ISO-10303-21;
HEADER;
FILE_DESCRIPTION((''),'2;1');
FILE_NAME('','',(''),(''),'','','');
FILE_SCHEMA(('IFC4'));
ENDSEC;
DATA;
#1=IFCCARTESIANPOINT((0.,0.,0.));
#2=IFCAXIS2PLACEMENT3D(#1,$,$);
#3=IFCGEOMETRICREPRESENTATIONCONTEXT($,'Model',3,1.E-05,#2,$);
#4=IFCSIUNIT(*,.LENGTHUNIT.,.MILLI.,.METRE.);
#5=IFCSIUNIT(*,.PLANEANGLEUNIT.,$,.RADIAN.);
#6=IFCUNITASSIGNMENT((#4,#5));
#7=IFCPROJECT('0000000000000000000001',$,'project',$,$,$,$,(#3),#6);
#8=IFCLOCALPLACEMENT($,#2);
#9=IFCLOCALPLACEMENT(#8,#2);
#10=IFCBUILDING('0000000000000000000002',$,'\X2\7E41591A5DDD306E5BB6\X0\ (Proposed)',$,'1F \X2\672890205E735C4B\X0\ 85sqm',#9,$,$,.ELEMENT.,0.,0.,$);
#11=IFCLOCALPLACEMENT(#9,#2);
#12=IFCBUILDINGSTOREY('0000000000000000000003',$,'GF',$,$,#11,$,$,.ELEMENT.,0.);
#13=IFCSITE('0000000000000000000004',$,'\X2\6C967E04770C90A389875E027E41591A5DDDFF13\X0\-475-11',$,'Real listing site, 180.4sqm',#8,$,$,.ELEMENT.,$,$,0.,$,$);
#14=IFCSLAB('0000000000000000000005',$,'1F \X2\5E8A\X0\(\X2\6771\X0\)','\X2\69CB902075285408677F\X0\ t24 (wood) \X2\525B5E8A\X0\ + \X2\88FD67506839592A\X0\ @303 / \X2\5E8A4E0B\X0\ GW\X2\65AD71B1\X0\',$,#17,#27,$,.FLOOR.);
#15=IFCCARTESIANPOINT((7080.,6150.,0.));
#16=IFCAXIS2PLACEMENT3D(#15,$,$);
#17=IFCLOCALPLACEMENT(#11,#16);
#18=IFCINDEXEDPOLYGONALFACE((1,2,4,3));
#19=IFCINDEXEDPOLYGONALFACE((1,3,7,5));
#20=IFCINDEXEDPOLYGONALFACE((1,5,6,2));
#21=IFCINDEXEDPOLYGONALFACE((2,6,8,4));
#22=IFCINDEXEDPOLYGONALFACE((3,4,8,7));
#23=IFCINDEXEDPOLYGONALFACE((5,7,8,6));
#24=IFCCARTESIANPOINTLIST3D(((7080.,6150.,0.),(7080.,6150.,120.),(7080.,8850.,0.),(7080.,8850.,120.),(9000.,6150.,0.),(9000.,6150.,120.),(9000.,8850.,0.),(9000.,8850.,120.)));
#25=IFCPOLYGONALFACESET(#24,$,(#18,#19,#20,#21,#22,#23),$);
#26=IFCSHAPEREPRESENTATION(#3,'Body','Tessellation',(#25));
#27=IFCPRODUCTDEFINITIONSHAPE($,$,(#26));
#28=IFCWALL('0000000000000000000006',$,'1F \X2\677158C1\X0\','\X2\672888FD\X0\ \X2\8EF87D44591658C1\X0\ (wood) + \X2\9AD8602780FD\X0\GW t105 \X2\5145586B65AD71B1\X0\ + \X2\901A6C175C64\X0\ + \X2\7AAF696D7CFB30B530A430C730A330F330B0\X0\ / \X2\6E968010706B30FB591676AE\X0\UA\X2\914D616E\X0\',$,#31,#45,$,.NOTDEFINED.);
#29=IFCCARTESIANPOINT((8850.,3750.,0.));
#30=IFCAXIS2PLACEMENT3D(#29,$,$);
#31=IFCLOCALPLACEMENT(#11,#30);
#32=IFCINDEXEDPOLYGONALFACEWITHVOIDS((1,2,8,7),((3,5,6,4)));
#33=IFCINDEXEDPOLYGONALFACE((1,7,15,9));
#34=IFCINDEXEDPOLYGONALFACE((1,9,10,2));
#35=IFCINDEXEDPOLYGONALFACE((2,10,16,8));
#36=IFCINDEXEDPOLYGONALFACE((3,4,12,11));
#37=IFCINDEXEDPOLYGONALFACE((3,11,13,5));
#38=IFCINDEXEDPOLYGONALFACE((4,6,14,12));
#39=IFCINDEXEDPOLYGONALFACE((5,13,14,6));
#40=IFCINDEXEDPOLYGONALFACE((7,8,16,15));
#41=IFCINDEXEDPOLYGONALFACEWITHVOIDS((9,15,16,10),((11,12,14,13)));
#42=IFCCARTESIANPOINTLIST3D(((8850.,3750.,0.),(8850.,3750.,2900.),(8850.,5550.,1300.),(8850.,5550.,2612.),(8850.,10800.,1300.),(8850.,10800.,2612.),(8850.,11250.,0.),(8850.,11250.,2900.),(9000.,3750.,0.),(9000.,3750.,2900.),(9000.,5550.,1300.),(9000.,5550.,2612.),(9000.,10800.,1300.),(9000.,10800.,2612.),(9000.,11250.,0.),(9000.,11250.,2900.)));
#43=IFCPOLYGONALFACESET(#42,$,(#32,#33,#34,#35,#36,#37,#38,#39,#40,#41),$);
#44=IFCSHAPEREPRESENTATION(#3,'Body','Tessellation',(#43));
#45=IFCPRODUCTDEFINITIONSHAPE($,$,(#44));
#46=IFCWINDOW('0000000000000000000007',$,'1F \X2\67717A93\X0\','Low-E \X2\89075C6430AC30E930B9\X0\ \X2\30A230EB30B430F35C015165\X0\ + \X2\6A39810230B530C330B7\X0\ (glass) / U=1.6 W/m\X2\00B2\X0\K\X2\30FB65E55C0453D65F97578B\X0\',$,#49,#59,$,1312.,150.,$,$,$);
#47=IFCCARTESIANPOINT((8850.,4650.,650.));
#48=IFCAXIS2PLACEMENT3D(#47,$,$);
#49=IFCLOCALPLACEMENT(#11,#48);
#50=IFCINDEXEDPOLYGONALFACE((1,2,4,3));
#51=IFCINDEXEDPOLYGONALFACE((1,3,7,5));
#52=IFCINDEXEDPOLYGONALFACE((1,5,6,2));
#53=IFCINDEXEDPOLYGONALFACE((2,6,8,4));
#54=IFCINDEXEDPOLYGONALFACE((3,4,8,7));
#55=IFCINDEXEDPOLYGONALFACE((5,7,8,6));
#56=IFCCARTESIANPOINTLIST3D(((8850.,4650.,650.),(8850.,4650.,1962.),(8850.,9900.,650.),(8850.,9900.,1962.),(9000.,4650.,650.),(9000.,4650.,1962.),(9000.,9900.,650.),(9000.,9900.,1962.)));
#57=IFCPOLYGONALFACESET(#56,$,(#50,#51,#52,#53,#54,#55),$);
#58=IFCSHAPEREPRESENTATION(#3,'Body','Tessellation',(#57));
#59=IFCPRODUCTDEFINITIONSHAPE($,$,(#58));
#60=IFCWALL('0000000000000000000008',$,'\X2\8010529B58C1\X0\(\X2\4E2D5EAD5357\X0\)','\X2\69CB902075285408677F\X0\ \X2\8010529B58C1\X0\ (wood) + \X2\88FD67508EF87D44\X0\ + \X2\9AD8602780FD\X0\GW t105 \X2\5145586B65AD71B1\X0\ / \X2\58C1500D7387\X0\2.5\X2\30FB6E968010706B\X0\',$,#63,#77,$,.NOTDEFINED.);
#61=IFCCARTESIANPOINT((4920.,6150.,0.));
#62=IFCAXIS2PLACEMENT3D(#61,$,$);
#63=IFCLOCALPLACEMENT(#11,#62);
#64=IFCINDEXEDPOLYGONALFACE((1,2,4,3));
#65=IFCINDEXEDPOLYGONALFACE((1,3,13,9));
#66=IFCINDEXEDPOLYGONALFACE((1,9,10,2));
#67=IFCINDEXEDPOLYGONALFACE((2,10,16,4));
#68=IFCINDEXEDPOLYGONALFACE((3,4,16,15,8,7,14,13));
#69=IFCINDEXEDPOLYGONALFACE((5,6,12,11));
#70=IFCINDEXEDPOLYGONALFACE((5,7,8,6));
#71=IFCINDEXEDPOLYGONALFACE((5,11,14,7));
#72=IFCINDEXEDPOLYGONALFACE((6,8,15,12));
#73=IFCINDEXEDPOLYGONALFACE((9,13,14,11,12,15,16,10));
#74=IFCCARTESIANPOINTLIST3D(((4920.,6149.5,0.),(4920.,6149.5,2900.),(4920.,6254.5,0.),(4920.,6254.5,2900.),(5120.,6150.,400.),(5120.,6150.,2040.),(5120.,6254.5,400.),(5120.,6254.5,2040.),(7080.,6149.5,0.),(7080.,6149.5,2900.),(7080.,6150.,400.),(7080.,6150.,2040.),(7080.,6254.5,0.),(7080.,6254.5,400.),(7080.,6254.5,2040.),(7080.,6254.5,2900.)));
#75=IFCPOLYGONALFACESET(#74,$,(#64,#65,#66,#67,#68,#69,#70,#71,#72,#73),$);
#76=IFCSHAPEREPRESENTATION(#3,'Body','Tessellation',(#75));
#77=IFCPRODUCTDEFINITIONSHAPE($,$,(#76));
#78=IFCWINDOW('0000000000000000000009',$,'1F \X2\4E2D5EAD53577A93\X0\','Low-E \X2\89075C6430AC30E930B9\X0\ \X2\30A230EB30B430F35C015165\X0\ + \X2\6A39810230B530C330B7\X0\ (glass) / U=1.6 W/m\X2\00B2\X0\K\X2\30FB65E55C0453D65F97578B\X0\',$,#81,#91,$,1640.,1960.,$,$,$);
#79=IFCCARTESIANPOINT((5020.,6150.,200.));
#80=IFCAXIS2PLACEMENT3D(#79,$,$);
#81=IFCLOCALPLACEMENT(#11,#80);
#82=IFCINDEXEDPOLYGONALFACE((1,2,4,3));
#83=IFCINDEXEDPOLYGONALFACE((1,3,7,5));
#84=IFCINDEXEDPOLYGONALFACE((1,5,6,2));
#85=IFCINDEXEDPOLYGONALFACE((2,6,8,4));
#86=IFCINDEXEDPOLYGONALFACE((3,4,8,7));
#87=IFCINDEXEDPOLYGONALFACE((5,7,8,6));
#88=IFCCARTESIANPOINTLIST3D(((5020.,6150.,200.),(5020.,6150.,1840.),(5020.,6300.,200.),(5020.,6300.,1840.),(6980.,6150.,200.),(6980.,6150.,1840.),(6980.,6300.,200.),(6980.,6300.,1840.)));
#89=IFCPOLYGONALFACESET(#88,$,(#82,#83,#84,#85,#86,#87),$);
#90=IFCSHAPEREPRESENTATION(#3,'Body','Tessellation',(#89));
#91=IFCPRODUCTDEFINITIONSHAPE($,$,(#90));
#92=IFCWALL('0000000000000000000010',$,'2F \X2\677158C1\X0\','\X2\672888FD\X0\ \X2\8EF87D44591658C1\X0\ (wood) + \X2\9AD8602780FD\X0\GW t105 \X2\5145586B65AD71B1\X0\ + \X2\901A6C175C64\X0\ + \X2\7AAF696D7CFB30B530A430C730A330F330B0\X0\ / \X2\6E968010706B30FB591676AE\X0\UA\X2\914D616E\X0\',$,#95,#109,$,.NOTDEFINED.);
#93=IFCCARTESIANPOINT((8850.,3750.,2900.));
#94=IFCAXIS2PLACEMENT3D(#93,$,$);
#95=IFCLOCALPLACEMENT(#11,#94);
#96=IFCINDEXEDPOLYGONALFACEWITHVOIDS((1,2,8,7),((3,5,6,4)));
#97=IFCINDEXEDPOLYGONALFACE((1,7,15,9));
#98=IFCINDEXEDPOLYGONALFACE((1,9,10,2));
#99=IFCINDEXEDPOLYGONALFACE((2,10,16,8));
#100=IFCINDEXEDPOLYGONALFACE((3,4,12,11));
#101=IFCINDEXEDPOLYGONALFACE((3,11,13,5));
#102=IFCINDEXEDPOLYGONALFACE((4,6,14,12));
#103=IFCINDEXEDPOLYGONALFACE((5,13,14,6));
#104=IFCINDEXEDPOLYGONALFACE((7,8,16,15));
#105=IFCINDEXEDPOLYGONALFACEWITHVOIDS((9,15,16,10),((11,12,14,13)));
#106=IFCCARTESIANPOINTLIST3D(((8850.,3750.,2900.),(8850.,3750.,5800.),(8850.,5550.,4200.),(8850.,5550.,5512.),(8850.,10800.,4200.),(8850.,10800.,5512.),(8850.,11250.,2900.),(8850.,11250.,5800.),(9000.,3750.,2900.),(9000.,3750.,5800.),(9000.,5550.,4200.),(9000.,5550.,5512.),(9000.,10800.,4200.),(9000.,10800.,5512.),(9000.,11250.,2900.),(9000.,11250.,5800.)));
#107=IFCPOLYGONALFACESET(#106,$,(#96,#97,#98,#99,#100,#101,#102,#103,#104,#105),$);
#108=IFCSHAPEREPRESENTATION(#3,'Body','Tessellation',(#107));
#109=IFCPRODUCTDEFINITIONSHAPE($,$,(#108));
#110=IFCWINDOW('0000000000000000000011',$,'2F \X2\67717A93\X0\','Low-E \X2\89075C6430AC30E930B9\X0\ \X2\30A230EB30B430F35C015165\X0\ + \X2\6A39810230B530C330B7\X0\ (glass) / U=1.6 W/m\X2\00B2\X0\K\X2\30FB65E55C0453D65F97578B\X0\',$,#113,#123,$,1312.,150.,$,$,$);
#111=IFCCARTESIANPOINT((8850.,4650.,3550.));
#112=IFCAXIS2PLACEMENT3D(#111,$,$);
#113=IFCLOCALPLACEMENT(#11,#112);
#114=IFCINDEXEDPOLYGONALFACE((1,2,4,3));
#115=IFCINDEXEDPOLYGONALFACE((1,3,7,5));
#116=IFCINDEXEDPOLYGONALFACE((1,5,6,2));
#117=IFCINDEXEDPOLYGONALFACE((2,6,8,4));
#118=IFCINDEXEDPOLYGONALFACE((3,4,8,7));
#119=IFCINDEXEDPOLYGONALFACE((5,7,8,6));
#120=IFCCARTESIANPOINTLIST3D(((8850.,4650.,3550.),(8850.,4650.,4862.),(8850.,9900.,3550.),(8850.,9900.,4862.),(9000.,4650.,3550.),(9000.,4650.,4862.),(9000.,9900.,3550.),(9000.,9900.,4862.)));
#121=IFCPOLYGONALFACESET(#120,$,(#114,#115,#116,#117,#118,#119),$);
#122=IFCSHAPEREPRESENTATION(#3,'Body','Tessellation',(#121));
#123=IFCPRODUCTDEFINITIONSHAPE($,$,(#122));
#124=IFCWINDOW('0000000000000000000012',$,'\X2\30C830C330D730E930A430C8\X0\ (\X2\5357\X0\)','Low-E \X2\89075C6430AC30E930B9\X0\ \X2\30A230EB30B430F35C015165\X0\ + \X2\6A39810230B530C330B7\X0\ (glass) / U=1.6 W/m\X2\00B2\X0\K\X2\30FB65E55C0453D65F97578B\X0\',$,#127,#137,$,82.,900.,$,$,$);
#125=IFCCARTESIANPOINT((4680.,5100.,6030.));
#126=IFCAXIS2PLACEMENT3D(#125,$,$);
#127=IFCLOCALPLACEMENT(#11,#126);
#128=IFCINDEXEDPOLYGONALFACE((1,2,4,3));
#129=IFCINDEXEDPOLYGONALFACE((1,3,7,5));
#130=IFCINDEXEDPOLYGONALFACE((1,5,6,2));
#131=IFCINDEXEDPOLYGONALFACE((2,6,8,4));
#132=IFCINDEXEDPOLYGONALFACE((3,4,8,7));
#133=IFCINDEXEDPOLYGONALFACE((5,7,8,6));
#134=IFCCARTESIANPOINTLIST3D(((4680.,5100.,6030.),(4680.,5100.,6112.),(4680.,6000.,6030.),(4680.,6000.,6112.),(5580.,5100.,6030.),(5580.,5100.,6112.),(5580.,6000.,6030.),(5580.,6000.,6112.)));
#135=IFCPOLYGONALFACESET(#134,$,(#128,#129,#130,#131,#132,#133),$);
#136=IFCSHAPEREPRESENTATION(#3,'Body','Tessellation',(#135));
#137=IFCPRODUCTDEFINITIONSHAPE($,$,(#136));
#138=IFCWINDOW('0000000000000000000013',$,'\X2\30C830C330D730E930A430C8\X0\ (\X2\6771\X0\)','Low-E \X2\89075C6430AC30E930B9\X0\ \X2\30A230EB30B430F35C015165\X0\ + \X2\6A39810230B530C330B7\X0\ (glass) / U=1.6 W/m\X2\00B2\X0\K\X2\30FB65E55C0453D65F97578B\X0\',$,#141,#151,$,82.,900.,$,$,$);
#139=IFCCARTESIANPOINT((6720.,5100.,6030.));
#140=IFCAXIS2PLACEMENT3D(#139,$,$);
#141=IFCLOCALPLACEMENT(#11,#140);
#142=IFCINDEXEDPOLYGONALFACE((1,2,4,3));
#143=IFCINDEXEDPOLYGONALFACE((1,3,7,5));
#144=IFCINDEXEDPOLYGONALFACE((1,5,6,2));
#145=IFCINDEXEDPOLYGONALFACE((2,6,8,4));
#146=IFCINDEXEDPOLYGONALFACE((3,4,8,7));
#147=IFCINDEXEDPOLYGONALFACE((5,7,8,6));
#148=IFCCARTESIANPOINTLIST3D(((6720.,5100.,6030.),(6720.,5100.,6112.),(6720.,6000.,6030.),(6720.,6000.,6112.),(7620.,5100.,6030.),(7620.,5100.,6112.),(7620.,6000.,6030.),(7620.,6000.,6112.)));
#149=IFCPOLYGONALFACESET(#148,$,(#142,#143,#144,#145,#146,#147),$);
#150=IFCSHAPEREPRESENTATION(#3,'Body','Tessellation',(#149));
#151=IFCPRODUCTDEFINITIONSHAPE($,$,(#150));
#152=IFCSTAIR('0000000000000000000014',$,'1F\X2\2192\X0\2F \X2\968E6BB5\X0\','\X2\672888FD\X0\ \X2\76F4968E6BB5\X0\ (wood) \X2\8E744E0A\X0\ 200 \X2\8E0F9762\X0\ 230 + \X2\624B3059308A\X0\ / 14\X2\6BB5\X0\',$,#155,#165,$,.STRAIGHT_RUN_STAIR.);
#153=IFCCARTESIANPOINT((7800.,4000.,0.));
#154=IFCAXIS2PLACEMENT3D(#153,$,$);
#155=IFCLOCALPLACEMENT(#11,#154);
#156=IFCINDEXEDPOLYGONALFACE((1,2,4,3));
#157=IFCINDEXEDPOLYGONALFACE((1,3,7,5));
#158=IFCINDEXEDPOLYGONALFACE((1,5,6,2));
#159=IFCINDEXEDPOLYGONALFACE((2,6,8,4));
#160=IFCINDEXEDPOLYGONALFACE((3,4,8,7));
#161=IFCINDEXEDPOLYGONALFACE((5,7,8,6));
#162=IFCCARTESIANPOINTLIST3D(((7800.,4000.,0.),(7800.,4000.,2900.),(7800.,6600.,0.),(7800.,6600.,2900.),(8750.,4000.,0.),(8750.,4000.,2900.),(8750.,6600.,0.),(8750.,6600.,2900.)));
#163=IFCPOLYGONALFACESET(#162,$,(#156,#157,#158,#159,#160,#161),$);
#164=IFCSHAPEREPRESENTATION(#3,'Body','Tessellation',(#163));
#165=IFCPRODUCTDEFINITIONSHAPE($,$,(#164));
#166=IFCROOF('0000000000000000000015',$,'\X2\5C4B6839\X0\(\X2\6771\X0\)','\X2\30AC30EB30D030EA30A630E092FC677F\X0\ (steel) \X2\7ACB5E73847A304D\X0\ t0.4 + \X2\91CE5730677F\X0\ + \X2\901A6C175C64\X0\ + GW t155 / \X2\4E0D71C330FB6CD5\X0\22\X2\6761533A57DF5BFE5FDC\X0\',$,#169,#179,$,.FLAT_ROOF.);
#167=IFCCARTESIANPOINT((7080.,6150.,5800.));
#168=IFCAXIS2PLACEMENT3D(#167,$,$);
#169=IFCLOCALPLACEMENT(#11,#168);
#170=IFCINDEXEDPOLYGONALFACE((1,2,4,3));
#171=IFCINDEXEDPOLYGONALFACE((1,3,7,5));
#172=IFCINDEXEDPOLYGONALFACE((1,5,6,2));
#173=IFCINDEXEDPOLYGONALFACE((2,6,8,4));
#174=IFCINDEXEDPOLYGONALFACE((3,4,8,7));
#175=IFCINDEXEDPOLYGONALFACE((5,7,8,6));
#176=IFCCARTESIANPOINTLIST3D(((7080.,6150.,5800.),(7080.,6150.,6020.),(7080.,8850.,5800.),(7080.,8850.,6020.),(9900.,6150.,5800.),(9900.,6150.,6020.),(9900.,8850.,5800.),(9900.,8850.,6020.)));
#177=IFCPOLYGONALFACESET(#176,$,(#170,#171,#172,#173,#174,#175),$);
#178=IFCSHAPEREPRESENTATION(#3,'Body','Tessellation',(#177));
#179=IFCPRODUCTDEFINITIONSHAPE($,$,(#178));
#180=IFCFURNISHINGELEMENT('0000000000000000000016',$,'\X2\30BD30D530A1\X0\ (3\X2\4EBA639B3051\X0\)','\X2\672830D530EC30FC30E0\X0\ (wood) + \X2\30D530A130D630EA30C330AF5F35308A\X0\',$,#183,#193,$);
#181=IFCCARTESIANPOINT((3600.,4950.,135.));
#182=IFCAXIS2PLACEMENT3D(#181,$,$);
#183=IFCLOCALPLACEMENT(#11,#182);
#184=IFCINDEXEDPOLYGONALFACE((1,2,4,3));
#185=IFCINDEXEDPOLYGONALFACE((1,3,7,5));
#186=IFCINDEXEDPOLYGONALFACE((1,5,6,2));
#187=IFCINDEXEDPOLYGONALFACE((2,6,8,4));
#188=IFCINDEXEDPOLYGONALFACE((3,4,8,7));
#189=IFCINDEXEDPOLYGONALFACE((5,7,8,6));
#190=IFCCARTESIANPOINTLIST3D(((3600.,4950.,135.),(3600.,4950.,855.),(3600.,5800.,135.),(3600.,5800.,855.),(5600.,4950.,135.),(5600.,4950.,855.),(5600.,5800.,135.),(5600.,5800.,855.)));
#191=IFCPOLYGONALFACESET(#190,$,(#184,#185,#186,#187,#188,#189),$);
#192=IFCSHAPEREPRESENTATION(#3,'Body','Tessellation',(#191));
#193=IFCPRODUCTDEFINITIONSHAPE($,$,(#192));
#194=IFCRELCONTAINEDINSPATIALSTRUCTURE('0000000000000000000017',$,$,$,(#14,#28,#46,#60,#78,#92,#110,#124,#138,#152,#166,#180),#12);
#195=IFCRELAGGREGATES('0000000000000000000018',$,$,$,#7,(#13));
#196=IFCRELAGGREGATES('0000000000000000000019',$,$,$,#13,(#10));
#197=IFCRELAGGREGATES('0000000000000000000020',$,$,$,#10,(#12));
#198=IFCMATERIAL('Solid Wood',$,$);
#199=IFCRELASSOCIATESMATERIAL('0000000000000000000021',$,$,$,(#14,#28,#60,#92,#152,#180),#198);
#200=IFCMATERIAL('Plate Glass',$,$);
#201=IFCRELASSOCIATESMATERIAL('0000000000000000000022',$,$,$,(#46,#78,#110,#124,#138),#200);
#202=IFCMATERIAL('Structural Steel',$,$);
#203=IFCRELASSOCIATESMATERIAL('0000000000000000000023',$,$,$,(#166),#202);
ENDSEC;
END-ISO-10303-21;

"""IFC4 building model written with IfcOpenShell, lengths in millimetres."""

from ifc_helpers import new_model, si_unit, frame, frame_2d, origin, place, context, project, spatial, rectangle, extrude, material, element, fill, save


model = new_model("IFC4")

# Units and contexts
model_context = context("Model", 3, precision=1e-05, world=origin())
ifc_project = project(units=[si_unit("LENGTHUNIT", "METRE", prefix="MILLI"), si_unit("PLANEANGLEUNIT", "RADIAN")], contexts=[model_context])

# Site, building, storey
site_placement = place(None, origin())
site = spatial("IfcSite", under=ifc_project, at=site_placement, Name="沖縄県那覇市繁多川３-475-11", ObjectType="Real listing site, 180.4sqm", CompositionType="ELEMENT", RefElevation=0.0)
building_placement = place(site_placement, origin())
building = spatial("IfcBuilding", under=site, at=building_placement, Name="繁多川の家 (Proposed)", ObjectType="1F 木造平屋 85sqm", CompositionType="ELEMENT", ElevationOfRefHeight=0.0, ElevationOfTerrain=0.0)
storey_placement = place(building_placement, origin())
storey = spatial("IfcBuildingStorey", under=building, at=storey_placement, Name="GF", CompositionType="ELEMENT", Elevation=0.0)

# Slab
ifc_material_1 = material(Name="Solid Wood")
slab_placement = place(storey_placement, frame((7080.0, 6150.0, 0.0)))
element("IfcSlab", 1, at=slab_placement, inside=storey, material=ifc_material_1, Name="1F 床(東)", Description="構造用合板 t24 (wood) 剛床 + 製材根太 @303 / 床下 GW断熱", PredefinedType="FLOOR", context=model_context, shape_type="SweptSolid", body=[
    extrude(rectangle(XDim=1920.0, YDim=2700.0, at=frame_2d((960.0, 1350.0))), frame((7080.0, 6150.0, 0.0)), (0.0, 0.0, 1.0), 120.0),
])

# Walls, openings, windows
wall_1_placement = place(storey_placement, frame((8850.0, 3750.0, 0.0)))
wall_1 = element("IfcWall", 2, at=wall_1_placement, inside=storey, material=ifc_material_1, Name="1F 東壁", Description="木製 軸組外壁 (wood) + 高性能GW t105 充填断熱 + 通気層 + 窯業系サイディング / 準耐火・外皮UA配慮", PredefinedType="NOTDEFINED", context=model_context, shape_type="SweptSolid", body=[
    extrude(rectangle(XDim=150.0, YDim=7500.0, at=frame_2d((75.0, 3750.0))), frame((8850.0, 3750.0, 0.0)), (0.0, 0.0, 1.0), 2900.0),
])
opening_1_placement = place(storey_placement, frame((8850.0, 4650.0, 650.0)))
opening_1 = element("IfcOpeningElement", 3, at=opening_1_placement, cuts=wall_1, PredefinedType="NOTDEFINED", context=model_context, shape_type="SweptSolid", body=[
    extrude(rectangle(XDim=150.0, YDim=5250.0, at=frame_2d((75.0, 2625.0))), frame((8850.0, 4650.0, 650.0)), (0.0, 0.0, 1.0), 1312.0),
])
ifc_material_2 = material(Name="Plate Glass")
window_1_placement = place(storey_placement, frame((8850.0, 4650.0, 650.0)))
window_1 = element("IfcWindow", 4, at=window_1_placement, inside=storey, material=ifc_material_2, Name="1F 東窓", Description="Low-E 複層ガラス アルゴン封入 + 樹脂サッシ (glass) / U=1.6 W/m²K・日射取得型", OverallHeight=1312.0, OverallWidth=150.0, context=model_context, shape_type="SweptSolid", body=[
    extrude(rectangle(XDim=150.0, YDim=5250.0, at=frame_2d((75.0, 2625.0))), frame((8850.0, 4650.0, 650.0)), (0.0, 0.0, 1.0), 1312.0),
])
fill(opening_1, window_1)
wall_2_placement = place(storey_placement, frame((4920.0, 6150.0, 0.0)))
wall_2 = element("IfcWall", 5, at=wall_2_placement, inside=storey, material=ifc_material_1, Name="耐力壁(中庭南)", Description="構造用合板 耐力壁 (wood) + 製材軸組 + 高性能GW t105 充填断熱 / 壁倍率2.5・準耐火", PredefinedType="NOTDEFINED", context=model_context, shape_type="SweptSolid", body=[
    extrude(rectangle(XDim=2160.0, YDim=105.0, at=frame_2d((1080.0, 52.0))), frame((4920.0, 6150.0, 0.0)), (0.0, 0.0, 1.0), 2900.0),
])
opening_2_placement = place(storey_placement, frame((5020.0, 6150.0, 200.0)))
opening_2 = element("IfcOpeningElement", 6, at=opening_2_placement, cuts=wall_2, PredefinedType="NOTDEFINED", context=model_context, shape_type="SweptSolid", body=[
    extrude(rectangle(XDim=1960.0, YDim=150.0, at=frame_2d((980.0, 75.0))), frame((5020.0, 6150.0, 200.0)), (0.0, 0.0, 1.0), 1640.0),
])
window_2_placement = place(storey_placement, frame((5020.0, 6150.0, 200.0)))
window_2 = element("IfcWindow", 7, at=window_2_placement, inside=storey, material=ifc_material_2, Name="1F 中庭南窓", Description="Low-E 複層ガラス アルゴン封入 + 樹脂サッシ (glass) / U=1.6 W/m²K・日射取得型", OverallHeight=1640.0, OverallWidth=1960.0, context=model_context, shape_type="SweptSolid", body=[
    extrude(rectangle(XDim=1960.0, YDim=150.0, at=frame_2d((980.0, 75.0))), frame((5020.0, 6150.0, 200.0)), (0.0, 0.0, 1.0), 1640.0),
])
fill(opening_2, window_2)

# Wall, opening, window
wall_3_placement = place(storey_placement, frame((8850.0, 3750.0, 2900.0)))
wall_3 = element("IfcWall", 8, at=wall_3_placement, inside=storey, material=ifc_material_1, Name="2F 東壁", Description="木製 軸組外壁 (wood) + 高性能GW t105 充填断熱 + 通気層 + 窯業系サイディング / 準耐火・外皮UA配慮", PredefinedType="NOTDEFINED", context=model_context, shape_type="SweptSolid", body=[
    extrude(rectangle(XDim=150.0, YDim=7500.0, at=frame_2d((75.0, 3750.0))), frame((8850.0, 3750.0, 2900.0)), (0.0, 0.0, 1.0), 2900.0),
])
opening_3_placement = place(storey_placement, frame((8850.0, 4650.0, 3550.0)))
opening_3 = element("IfcOpeningElement", 9, at=opening_3_placement, cuts=wall_3, PredefinedType="NOTDEFINED", context=model_context, shape_type="SweptSolid", body=[
    extrude(rectangle(XDim=150.0, YDim=5250.0, at=frame_2d((75.0, 2625.0))), frame((8850.0, 4650.0, 3550.0)), (0.0, 0.0, 1.0), 1312.0),
])
window_3_placement = place(storey_placement, frame((8850.0, 4650.0, 3550.0)))
window_3 = element("IfcWindow", 10, at=window_3_placement, inside=storey, material=ifc_material_2, Name="2F 東窓", Description="Low-E 複層ガラス アルゴン封入 + 樹脂サッシ (glass) / U=1.6 W/m²K・日射取得型", OverallHeight=1312.0, OverallWidth=150.0, context=model_context, shape_type="SweptSolid", body=[
    extrude(rectangle(XDim=150.0, YDim=5250.0, at=frame_2d((75.0, 2625.0))), frame((8850.0, 4650.0, 3550.0)), (0.0, 0.0, 1.0), 1312.0),
])
fill(opening_3, window_3)

# Windows
window_4_placement = place(storey_placement, frame((4680.0, 5100.0, 6030.0)))
element("IfcWindow", 11, at=window_4_placement, inside=storey, material=ifc_material_2, Name="トップライト (南)", Description="Low-E 複層ガラス アルゴン封入 + 樹脂サッシ (glass) / U=1.6 W/m²K・日射取得型", OverallHeight=82.0, OverallWidth=900.0, context=model_context, shape_type="SweptSolid", body=[
    extrude(rectangle(XDim=900.0, YDim=900.0, at=frame_2d((450.0, 450.0))), frame((4680.0, 5100.0, 6030.0)), (0.0, 0.0, 1.0), 82.0),
])
window_5_placement = place(storey_placement, frame((6720.0, 5100.0, 6030.0)))
element("IfcWindow", 12, at=window_5_placement, inside=storey, material=ifc_material_2, Name="トップライト (東)", Description="Low-E 複層ガラス アルゴン封入 + 樹脂サッシ (glass) / U=1.6 W/m²K・日射取得型", OverallHeight=82.0, OverallWidth=900.0, context=model_context, shape_type="SweptSolid", body=[
    extrude(rectangle(XDim=900.0, YDim=900.0, at=frame_2d((450.0, 450.0))), frame((6720.0, 5100.0, 6030.0)), (0.0, 0.0, 1.0), 82.0),
])

# Stair
stair_placement = place(storey_placement, frame((7800.0, 4000.0, 0.0)))
element("IfcStair", 13, at=stair_placement, inside=storey, material=ifc_material_1, Name="1F→2F 階段", Description="木製 直階段 (wood) 蹴上 200 踏面 230 + 手すり / 14段", PredefinedType="STRAIGHT_RUN_STAIR", context=model_context, shape_type="SweptSolid", body=[
    extrude(rectangle(XDim=950.0, YDim=2600.0, at=frame_2d((475.0, 1300.0))), frame((7800.0, 4000.0, 0.0)), (0.0, 0.0, 1.0), 2900.0),
])

# Roof
ifc_material_3 = material(Name="Structural Steel")
roof_placement = place(storey_placement, frame((7080.0, 6150.0, 5800.0)))
element("IfcRoof", 14, at=roof_placement, inside=storey, material=ifc_material_3, Name="屋根(東)", Description="ガルバリウム鋼板 (steel) 立平葺き t0.4 + 野地板 + 通気層 + GW t155 / 不燃・法22条区域対応", PredefinedType="FLAT_ROOF", context=model_context, shape_type="SweptSolid", body=[
    extrude(rectangle(XDim=2820.0, YDim=2700.0, at=frame_2d((1410.0, 1350.0))), frame((7080.0, 6150.0, 5800.0)), (0.0, 0.0, 1.0), 220.0),
])

# Furnishing element
furnishing_1_placement = place(storey_placement, frame((3600.0, 4950.0, 135.0)))
element("IfcFurnishingElement", 15, at=furnishing_1_placement, inside=storey, material=ifc_material_1, Name="ソファ (3人掛け)", Description="木フレーム (wood) + ファブリック張り", context=model_context, shape_type="SweptSolid", body=[
    extrude(rectangle(XDim=2000.0, YDim=850.0, at=frame_2d((1000.0, 425.0))), frame((3600.0, 4950.0, 135.0)), (0.0, 0.0, 1.0), 720.0),
])

save(model, "model.ifc")
